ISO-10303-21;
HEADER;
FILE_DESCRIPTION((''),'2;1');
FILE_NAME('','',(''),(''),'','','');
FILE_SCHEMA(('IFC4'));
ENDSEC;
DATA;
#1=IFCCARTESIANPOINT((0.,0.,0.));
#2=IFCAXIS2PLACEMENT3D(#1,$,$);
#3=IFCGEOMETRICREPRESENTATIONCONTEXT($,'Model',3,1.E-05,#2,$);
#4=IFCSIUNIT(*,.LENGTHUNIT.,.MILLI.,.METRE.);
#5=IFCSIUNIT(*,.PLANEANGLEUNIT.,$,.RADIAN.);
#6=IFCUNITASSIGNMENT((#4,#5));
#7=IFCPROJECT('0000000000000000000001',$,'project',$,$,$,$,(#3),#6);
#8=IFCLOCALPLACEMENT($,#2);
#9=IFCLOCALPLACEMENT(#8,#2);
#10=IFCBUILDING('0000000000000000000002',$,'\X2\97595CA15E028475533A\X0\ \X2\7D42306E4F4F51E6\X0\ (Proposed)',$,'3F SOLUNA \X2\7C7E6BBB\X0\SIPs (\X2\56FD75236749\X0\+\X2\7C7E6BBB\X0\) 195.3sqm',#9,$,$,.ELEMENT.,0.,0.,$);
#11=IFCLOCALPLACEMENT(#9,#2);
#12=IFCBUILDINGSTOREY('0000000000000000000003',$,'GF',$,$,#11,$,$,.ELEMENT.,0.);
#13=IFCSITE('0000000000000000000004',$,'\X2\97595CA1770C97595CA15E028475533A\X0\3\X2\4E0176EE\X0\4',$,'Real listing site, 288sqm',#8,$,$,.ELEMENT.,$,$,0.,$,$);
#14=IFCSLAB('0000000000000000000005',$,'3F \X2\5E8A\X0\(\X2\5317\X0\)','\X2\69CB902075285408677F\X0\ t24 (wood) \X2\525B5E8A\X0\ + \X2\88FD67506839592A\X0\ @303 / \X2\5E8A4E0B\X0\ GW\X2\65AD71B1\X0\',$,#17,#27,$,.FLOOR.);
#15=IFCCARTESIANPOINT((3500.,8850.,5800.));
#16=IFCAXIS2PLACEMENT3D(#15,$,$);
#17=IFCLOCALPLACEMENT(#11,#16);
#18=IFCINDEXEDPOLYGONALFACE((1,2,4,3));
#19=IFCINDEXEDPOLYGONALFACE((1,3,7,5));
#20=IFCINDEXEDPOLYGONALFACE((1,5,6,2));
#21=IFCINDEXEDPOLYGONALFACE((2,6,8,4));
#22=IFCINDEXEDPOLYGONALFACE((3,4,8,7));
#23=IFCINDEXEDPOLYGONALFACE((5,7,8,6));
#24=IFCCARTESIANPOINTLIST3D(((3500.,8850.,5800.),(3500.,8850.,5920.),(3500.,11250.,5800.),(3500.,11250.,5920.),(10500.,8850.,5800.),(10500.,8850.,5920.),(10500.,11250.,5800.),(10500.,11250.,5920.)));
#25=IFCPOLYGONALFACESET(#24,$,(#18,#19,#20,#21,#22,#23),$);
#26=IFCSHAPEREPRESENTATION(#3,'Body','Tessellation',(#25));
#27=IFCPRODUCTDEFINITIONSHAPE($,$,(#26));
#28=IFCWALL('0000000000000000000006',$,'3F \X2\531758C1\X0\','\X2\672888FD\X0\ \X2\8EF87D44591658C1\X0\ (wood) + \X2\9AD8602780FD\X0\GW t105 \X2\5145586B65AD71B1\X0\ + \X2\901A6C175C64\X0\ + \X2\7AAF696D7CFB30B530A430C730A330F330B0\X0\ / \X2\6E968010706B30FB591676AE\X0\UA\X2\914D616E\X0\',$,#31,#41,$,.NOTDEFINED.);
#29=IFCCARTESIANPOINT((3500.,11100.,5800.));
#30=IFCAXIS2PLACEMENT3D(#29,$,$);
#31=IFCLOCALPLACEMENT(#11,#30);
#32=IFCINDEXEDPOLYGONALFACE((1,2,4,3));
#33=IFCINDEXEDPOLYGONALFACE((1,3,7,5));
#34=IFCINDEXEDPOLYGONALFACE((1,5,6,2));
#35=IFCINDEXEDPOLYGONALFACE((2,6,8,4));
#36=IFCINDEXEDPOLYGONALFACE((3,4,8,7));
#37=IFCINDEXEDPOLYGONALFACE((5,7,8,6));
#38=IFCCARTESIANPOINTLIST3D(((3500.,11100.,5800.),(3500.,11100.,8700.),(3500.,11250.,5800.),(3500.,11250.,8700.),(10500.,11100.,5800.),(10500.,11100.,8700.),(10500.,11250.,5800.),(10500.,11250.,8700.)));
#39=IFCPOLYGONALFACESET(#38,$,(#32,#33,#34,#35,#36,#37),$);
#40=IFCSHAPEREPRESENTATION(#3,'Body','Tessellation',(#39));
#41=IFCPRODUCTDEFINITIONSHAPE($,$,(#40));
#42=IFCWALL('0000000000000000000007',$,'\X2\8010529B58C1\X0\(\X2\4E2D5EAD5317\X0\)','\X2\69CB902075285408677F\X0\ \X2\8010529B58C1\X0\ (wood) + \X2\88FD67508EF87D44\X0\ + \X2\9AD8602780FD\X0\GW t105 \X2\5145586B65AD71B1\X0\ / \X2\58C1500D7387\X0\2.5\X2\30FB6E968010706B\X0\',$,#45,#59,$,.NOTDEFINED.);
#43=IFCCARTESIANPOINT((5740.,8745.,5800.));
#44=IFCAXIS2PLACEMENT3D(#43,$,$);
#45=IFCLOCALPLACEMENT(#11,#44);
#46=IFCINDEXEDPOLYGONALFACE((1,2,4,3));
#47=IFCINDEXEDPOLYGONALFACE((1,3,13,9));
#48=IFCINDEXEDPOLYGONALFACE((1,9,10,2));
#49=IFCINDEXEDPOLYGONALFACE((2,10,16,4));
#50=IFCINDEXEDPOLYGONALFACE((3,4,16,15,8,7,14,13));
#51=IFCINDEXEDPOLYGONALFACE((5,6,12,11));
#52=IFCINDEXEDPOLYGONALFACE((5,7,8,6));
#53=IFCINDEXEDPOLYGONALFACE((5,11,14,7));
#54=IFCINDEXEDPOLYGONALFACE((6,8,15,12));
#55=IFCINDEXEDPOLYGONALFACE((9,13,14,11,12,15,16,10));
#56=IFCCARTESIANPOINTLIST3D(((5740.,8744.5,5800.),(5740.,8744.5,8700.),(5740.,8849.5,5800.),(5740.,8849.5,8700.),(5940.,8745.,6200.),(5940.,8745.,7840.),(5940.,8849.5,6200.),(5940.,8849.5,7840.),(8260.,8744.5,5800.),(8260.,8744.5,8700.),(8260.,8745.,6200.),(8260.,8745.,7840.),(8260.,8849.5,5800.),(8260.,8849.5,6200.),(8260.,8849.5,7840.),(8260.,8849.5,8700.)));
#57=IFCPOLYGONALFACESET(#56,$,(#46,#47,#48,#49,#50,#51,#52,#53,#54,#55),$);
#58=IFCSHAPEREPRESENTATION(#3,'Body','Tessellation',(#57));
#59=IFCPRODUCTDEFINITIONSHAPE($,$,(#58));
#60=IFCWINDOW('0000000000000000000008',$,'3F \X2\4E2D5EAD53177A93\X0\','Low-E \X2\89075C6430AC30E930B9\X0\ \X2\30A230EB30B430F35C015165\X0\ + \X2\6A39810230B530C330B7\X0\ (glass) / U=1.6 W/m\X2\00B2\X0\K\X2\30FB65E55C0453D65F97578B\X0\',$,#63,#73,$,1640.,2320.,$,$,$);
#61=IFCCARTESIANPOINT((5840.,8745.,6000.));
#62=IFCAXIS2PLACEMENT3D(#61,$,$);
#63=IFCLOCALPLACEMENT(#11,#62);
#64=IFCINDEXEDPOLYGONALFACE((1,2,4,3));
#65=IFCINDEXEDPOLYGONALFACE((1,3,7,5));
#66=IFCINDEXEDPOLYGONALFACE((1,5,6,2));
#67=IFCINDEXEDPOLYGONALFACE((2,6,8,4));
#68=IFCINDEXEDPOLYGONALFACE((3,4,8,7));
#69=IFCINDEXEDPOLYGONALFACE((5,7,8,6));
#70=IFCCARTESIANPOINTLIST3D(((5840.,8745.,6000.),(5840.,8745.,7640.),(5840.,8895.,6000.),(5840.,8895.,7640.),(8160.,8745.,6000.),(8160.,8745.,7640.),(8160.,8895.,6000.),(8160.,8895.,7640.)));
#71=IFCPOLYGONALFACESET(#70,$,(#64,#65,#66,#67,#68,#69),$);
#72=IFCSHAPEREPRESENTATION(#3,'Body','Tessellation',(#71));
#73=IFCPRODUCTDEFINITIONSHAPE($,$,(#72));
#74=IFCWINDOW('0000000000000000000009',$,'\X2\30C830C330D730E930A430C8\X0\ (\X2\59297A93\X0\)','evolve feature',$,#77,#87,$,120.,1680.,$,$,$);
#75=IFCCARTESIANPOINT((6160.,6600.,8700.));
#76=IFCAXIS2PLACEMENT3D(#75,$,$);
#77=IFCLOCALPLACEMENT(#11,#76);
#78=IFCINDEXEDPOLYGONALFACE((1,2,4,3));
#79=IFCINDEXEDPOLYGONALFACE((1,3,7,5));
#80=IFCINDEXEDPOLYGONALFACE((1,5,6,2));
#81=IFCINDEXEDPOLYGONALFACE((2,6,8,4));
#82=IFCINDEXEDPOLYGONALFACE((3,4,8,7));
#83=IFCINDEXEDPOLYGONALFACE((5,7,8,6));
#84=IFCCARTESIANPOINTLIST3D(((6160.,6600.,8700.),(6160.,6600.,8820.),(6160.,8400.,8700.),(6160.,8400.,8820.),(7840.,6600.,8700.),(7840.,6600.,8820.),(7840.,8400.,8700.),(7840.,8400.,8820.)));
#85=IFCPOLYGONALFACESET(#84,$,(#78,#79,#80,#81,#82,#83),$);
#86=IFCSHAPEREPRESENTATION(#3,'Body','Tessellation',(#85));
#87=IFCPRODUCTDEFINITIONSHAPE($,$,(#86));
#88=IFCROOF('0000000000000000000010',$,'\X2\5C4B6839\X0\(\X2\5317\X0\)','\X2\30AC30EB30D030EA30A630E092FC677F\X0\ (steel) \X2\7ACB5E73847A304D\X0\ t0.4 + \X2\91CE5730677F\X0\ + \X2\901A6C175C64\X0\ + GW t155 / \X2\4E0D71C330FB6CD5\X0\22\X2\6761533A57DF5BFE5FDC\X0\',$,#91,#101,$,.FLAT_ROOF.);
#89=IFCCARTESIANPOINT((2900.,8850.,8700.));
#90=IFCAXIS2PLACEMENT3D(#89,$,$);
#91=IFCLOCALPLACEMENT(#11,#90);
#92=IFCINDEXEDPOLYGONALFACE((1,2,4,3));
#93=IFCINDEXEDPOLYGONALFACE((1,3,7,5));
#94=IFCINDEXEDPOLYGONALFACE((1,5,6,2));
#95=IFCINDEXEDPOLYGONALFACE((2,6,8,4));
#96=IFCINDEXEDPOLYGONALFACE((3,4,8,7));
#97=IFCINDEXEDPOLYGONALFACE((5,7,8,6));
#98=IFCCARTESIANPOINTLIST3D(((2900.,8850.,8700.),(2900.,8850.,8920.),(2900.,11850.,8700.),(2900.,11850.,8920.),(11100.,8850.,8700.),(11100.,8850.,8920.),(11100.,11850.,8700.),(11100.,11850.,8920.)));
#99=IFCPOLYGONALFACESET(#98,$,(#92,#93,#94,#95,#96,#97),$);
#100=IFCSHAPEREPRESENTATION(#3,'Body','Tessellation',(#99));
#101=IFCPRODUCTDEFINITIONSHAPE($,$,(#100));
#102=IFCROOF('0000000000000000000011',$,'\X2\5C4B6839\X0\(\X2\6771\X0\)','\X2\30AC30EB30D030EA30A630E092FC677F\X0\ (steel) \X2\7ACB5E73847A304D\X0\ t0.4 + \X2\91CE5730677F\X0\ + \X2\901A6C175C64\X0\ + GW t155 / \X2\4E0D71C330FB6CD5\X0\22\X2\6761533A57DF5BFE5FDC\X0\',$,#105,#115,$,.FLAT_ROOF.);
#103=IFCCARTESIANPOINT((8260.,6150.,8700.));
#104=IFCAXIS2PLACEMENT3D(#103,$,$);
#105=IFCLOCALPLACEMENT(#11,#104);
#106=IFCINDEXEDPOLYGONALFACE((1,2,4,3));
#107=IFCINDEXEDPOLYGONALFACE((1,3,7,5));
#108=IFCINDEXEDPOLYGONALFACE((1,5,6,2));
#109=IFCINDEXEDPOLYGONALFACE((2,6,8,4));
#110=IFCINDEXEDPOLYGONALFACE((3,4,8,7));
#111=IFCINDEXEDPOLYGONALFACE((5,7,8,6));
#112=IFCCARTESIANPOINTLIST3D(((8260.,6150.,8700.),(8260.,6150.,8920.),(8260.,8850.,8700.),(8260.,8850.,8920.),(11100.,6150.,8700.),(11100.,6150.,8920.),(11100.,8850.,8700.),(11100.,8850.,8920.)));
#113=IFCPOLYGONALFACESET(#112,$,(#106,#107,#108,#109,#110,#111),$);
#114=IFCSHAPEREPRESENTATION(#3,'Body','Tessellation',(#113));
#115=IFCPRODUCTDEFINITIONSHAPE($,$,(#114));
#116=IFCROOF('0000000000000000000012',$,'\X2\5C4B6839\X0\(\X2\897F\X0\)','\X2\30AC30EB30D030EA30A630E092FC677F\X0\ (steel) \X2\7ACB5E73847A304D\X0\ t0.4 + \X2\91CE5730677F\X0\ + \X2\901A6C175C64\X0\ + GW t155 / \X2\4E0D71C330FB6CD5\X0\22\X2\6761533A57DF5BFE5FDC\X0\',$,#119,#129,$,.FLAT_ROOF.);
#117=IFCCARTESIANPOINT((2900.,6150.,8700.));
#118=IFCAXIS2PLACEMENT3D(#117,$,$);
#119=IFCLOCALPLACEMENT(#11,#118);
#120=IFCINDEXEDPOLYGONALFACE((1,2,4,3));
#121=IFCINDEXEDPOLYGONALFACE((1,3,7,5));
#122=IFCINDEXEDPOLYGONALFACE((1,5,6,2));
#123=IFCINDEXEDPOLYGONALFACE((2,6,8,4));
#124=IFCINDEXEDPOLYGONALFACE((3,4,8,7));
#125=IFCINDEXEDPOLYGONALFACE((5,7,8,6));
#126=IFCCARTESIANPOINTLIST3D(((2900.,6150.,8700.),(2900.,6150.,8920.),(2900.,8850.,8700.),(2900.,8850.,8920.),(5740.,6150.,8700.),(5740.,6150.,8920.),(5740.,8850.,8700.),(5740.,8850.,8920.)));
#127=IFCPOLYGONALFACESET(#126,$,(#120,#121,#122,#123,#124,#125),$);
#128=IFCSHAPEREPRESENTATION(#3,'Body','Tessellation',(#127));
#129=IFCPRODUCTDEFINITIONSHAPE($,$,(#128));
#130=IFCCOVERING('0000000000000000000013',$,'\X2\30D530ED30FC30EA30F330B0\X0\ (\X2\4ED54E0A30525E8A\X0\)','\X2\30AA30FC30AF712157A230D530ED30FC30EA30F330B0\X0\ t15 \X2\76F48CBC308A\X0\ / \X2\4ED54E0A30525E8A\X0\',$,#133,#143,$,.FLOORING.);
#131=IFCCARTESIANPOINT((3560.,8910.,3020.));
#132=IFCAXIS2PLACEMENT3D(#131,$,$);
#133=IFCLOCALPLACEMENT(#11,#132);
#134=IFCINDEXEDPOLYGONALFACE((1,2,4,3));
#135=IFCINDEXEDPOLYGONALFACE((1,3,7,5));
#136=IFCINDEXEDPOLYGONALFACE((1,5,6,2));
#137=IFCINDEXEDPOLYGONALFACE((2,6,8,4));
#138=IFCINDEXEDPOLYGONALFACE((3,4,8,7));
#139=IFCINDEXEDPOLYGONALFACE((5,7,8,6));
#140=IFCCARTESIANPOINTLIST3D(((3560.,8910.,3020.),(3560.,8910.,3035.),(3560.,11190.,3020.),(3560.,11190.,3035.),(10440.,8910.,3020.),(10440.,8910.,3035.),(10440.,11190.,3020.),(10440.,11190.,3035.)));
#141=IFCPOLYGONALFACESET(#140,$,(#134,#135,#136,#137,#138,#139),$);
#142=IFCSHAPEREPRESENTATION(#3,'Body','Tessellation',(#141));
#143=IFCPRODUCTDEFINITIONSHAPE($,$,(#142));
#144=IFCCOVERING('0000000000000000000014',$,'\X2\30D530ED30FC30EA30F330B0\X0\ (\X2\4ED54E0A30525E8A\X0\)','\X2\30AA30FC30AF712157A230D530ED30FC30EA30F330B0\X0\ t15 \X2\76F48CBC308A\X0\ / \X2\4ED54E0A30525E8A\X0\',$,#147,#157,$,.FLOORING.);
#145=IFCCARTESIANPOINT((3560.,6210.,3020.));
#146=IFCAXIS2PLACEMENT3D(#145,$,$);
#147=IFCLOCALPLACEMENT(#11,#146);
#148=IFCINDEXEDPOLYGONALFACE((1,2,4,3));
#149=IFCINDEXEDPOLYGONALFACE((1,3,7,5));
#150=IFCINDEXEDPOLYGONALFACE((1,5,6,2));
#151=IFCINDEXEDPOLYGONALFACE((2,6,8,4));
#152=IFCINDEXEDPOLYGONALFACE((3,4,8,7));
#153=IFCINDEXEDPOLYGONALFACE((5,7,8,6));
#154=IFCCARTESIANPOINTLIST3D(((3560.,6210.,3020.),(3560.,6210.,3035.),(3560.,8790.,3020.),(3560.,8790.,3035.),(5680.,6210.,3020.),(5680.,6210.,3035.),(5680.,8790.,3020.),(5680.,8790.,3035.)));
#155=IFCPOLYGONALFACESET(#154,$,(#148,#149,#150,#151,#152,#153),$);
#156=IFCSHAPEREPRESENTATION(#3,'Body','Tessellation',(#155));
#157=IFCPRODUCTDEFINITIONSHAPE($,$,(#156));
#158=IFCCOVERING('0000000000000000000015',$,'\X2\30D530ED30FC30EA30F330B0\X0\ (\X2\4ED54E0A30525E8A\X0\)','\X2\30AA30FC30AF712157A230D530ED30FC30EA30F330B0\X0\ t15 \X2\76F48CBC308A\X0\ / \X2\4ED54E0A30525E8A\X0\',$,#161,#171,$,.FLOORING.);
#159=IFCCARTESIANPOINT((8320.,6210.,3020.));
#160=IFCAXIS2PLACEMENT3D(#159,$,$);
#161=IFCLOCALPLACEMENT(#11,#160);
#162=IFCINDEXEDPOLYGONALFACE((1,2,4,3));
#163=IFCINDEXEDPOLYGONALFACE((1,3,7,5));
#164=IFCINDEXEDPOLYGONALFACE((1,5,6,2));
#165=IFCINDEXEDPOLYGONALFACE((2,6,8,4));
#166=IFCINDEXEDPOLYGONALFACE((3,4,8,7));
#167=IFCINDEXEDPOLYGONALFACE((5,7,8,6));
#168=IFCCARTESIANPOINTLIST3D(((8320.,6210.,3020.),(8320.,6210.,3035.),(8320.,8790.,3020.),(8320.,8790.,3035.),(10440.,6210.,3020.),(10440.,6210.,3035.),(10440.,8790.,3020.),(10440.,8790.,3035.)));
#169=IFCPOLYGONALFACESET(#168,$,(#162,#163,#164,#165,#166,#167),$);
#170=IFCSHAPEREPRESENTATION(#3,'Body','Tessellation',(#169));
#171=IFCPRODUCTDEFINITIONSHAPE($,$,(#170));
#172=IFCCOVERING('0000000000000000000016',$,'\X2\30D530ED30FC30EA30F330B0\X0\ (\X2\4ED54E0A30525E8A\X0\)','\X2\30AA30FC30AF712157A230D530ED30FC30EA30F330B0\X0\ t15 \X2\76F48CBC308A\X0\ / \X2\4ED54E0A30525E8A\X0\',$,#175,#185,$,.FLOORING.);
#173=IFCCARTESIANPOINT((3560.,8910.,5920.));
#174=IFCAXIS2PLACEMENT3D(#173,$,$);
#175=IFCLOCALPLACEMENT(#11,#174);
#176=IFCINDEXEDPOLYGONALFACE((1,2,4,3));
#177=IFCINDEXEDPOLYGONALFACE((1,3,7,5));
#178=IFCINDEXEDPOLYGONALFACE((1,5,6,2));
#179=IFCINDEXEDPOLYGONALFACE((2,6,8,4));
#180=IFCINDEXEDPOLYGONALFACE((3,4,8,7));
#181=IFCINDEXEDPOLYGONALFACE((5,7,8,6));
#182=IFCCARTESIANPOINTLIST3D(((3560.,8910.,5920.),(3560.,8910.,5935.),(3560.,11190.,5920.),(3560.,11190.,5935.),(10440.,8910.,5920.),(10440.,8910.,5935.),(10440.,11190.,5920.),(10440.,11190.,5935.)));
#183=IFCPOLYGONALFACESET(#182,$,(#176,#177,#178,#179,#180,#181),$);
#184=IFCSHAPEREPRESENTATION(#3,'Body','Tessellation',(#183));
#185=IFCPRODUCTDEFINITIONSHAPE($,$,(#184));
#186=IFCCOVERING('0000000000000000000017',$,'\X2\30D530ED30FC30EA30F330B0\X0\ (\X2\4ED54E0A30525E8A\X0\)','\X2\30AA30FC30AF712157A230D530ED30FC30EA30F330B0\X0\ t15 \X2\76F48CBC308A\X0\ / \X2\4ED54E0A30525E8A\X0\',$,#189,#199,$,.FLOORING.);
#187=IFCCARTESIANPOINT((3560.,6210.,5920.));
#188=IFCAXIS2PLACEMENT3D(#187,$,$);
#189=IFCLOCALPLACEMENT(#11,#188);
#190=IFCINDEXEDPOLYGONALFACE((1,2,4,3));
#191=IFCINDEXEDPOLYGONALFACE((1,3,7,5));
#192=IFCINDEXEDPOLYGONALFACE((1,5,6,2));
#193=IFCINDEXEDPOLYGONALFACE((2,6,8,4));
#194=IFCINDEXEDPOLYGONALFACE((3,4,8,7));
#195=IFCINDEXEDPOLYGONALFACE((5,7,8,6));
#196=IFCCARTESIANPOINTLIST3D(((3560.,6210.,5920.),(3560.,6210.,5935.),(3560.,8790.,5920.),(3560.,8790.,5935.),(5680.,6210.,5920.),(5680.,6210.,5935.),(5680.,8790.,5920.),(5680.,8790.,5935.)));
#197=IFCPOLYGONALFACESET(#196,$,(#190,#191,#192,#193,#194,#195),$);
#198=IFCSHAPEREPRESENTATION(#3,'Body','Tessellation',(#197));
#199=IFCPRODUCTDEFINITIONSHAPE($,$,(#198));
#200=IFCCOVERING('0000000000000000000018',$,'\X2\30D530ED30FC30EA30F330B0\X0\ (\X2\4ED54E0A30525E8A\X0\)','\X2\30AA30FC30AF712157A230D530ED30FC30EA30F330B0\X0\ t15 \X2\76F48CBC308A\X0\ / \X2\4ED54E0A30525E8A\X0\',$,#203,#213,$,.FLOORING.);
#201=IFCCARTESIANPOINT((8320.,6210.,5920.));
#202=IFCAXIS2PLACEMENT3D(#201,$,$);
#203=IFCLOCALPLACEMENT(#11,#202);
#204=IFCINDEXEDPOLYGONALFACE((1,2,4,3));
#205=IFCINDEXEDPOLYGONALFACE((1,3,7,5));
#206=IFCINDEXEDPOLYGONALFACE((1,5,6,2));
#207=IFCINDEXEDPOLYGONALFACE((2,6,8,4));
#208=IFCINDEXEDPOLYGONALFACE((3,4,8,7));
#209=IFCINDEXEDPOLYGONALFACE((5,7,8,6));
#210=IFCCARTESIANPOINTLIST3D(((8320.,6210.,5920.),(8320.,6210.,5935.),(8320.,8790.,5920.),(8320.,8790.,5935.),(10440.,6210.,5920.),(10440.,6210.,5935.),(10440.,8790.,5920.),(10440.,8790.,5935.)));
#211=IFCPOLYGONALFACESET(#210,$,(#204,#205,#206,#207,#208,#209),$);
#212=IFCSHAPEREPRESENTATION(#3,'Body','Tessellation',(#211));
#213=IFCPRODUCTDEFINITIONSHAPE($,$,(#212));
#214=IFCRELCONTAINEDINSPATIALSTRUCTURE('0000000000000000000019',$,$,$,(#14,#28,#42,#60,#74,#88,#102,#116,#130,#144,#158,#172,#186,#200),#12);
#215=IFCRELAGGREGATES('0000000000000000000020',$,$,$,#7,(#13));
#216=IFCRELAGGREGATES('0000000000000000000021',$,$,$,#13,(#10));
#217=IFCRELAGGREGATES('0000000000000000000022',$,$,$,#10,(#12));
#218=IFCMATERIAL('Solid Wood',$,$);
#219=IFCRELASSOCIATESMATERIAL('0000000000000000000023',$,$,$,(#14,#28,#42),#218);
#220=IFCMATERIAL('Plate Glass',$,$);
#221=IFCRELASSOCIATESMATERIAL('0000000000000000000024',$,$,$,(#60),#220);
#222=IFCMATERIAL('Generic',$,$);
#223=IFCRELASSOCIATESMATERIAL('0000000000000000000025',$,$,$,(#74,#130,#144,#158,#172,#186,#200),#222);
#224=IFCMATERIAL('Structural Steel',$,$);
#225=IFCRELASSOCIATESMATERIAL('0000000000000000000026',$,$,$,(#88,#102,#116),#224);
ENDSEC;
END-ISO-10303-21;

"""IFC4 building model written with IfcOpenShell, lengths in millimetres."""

from ifc_helpers import new_model, si_unit, frame, frame_2d, origin, place, context, project, spatial, rectangle, extrude, material, element, fill, save


model = new_model("IFC4")

# Units and contexts
model_context = context("Model", 3, precision=1e-05, world=origin())
ifc_project = project(units=[si_unit("LENGTHUNIT", "METRE", prefix="MILLI"), si_unit("PLANEANGLEUNIT", "RADIAN")], contexts=[model_context])

# Site, building, storey
site_placement = place(None, origin())
site = spatial("IfcSite", under=ifc_project, at=site_placement, Name="静岡県静岡市葵区3丁目4", ObjectType="Real listing site, 288sqm", CompositionType="ELEMENT", RefElevation=0.0)
building_placement = place(site_placement, origin())
building = spatial("IfcBuilding", under=site, at=building_placement, Name="静岡市葵区 終の住処 (Proposed)", ObjectType="3F SOLUNA 籾殻SIPs (国産杉+籾殻) 195.3sqm", CompositionType="ELEMENT", ElevationOfRefHeight=0.0, ElevationOfTerrain=0.0)
storey_placement = place(building_placement, origin())
storey = spatial("IfcBuildingStorey", under=building, at=storey_placement, Name="GF", CompositionType="ELEMENT", Elevation=0.0)

# Slab
ifc_material_1 = material(Name="Solid Wood")
slab_placement = place(storey_placement, frame((3500.0, 8850.0, 5800.0)))
element("IfcSlab", 1, at=slab_placement, inside=storey, material=ifc_material_1, Name="3F 床(北)", Description="構造用合板 t24 (wood) 剛床 + 製材根太 @303 / 床下 GW断熱", PredefinedType="FLOOR", context=model_context, shape_type="SweptSolid", body=[
    extrude(rectangle(XDim=7000.0, YDim=2400.0, at=frame_2d((3500.0, 1200.0))), frame((3500.0, 8850.0, 5800.0)), (0.0, 0.0, 1.0), 120.0),
])

# Wall
wall_1_placement = place(storey_placement, frame((3500.0, 11100.0, 5800.0)))
element("IfcWall", 2, at=wall_1_placement, inside=storey, material=ifc_material_1, Name="3F 北壁", Description="木製 軸組外壁 (wood) + 高性能GW t105 充填断熱 + 通気層 + 窯業系サイディング / 準耐火・外皮UA配慮", PredefinedType="NOTDEFINED", context=model_context, shape_type="SweptSolid", body=[
    extrude(rectangle(XDim=7000.0, YDim=150.0, at=frame_2d((3500.0, 75.0))), frame((3500.0, 11100.0, 5800.0)), (0.0, 0.0, 1.0), 2900.0),
])

# Wall, opening, window
wall_2_placement = place(storey_placement, frame((5740.0, 8745.0, 5800.0)))
wall_2 = element("IfcWall", 3, at=wall_2_placement, inside=storey, material=ifc_material_1, Name="耐力壁(中庭北)", Description="構造用合板 耐力壁 (wood) + 製材軸組 + 高性能GW t105 充填断熱 / 壁倍率2.5・準耐火", PredefinedType="NOTDEFINED", context=model_context, shape_type="SweptSolid", body=[
    extrude(rectangle(XDim=2520.0, YDim=105.0, at=frame_2d((1260.0, 52.0))), frame((5740.0, 8745.0, 5800.0)), (0.0, 0.0, 1.0), 2900.0),
])
opening_placement = place(storey_placement, frame((5840.0, 8745.0, 6000.0)))
opening = element("IfcOpeningElement", 4, at=opening_placement, cuts=wall_2, PredefinedType="NOTDEFINED", context=model_context, shape_type="SweptSolid", body=[
    extrude(rectangle(XDim=2320.0, YDim=150.0, at=frame_2d((1160.0, 75.0))), frame((5840.0, 8745.0, 6000.0)), (0.0, 0.0, 1.0), 1640.0),
])
ifc_material_2 = material(Name="Plate Glass")
window_1_placement = place(storey_placement, frame((5840.0, 8745.0, 6000.0)))
window_1 = element("IfcWindow", 5, at=window_1_placement, inside=storey, material=ifc_material_2, Name="3F 中庭北窓", Description="Low-E 複層ガラス アルゴン封入 + 樹脂サッシ (glass) / U=1.6 W/m²K・日射取得型", OverallHeight=1640.0, OverallWidth=2320.0, context=model_context, shape_type="SweptSolid", body=[
    extrude(rectangle(XDim=2320.0, YDim=150.0, at=frame_2d((1160.0, 75.0))), frame((5840.0, 8745.0, 6000.0)), (0.0, 0.0, 1.0), 1640.0),
])
fill(opening, window_1)

# Window
ifc_material_3 = material(Name="Generic")
window_2_placement = place(storey_placement, frame((6160.0, 6600.0, 8700.0)))
element("IfcWindow", 6, at=window_2_placement, inside=storey, material=ifc_material_3, Name="トップライト (天窓)", Description="evolve feature", OverallHeight=120.0, OverallWidth=1680.0, context=model_context, shape_type="SweptSolid", body=[
    extrude(rectangle(XDim=1680.0, YDim=1800.0, at=frame_2d((840.0, 900.0))), frame((6160.0, 6600.0, 8700.0)), (0.0, 0.0, 1.0), 120.0),
])

# Roofs
ifc_material_4 = material(Name="Structural Steel")
roof_1_placement = place(storey_placement, frame((2900.0, 8850.0, 8700.0)))
element("IfcRoof", 7, at=roof_1_placement, inside=storey, material=ifc_material_4, Name="屋根(北)", Description="ガルバリウム鋼板 (steel) 立平葺き t0.4 + 野地板 + 通気層 + GW t155 / 不燃・法22条区域対応", PredefinedType="FLAT_ROOF", context=model_context, shape_type="SweptSolid", body=[
    extrude(rectangle(XDim=8200.0, YDim=3000.0, at=frame_2d((4100.0, 1500.0))), frame((2900.0, 8850.0, 8700.0)), (0.0, 0.0, 1.0), 220.0),
])
roof_2_placement = place(storey_placement, frame((8260.0, 6150.0, 8700.0)))
element("IfcRoof", 8, at=roof_2_placement, inside=storey, material=ifc_material_4, Name="屋根(東)", Description="ガルバリウム鋼板 (steel) 立平葺き t0.4 + 野地板 + 通気層 + GW t155 / 不燃・法22条区域対応", PredefinedType="FLAT_ROOF", context=model_context, shape_type="SweptSolid", body=[
    extrude(rectangle(XDim=2840.0, YDim=2700.0, at=frame_2d((1420.0, 1350.0))), frame((8260.0, 6150.0, 8700.0)), (0.0, 0.0, 1.0), 220.0),
])
roof_3_placement = place(storey_placement, frame((2900.0, 6150.0, 8700.0)))
element("IfcRoof", 9, at=roof_3_placement, inside=storey, material=ifc_material_4, Name="屋根(西)", Description="ガルバリウム鋼板 (steel) 立平葺き t0.4 + 野地板 + 通気層 + GW t155 / 不燃・法22条区域対応", PredefinedType="FLAT_ROOF", context=model_context, shape_type="SweptSolid", body=[
    extrude(rectangle(XDim=2840.0, YDim=2700.0, at=frame_2d((1420.0, 1350.0))), frame((2900.0, 6150.0, 8700.0)), (0.0, 0.0, 1.0), 220.0),
])

# Coverings
covering_1_placement = place(storey_placement, frame((3560.0, 8910.0, 3020.0)))
element("IfcCovering", 10, at=covering_1_placement, inside=storey, material=ifc_material_3, Name="フローリング (仕上げ床)", Description="オーク無垢フローリング t15 直貼り / 仕上げ床", PredefinedType="FLOORING", context=model_context, shape_type="SweptSolid", body=[
    extrude(rectangle(XDim=6880.0, YDim=2280.0, at=frame_2d((3440.0, 1140.0))), frame((3560.0, 8910.0, 3020.0)), (0.0, 0.0, 1.0), 15.0),
])
covering_2_placement = place(storey_placement, frame((3560.0, 6210.0, 3020.0)))
element("IfcCovering", 11, at=covering_2_placement, inside=storey, material=ifc_material_3, Name="フローリング (仕上げ床)", Description="オーク無垢フローリング t15 直貼り / 仕上げ床", PredefinedType="FLOORING", context=model_context, shape_type="SweptSolid", body=[
    extrude(rectangle(XDim=2120.0, YDim=2580.0, at=frame_2d((1060.0, 1290.0))), frame((3560.0, 6210.0, 3020.0)), (0.0, 0.0, 1.0), 15.0),
])
covering_3_placement = place(storey_placement, frame((8320.0, 6210.0, 3020.0)))
element("IfcCovering", 12, at=covering_3_placement, inside=storey, material=ifc_material_3, Name="フローリング (仕上げ床)", Description="オーク無垢フローリング t15 直貼り / 仕上げ床", PredefinedType="FLOORING", context=model_context, shape_type="SweptSolid", body=[
    extrude(rectangle(XDim=2120.0, YDim=2580.0, at=frame_2d((1060.0, 1290.0))), frame((8320.0, 6210.0, 3020.0)), (0.0, 0.0, 1.0), 15.0),
])
covering_4_placement = place(storey_placement, frame((3560.0, 8910.0, 5920.0)))
element("IfcCovering", 13, at=covering_4_placement, inside=storey, material=ifc_material_3, Name="フローリング (仕上げ床)", Description="オーク無垢フローリング t15 直貼り / 仕上げ床", PredefinedType="FLOORING", context=model_context, shape_type="SweptSolid", body=[
    extrude(rectangle(XDim=6880.0, YDim=2280.0, at=frame_2d((3440.0, 1140.0))), frame((3560.0, 8910.0, 5920.0)), (0.0, 0.0, 1.0), 15.0),
])
covering_5_placement = place(storey_placement, frame((3560.0, 6210.0, 5920.0)))
element("IfcCovering", 14, at=covering_5_placement, inside=storey, material=ifc_material_3, Name="フローリング (仕上げ床)", Description="オーク無垢フローリング t15 直貼り / 仕上げ床", PredefinedType="FLOORING", context=model_context, shape_type="SweptSolid", body=[
    extrude(rectangle(XDim=2120.0, YDim=2580.0, at=frame_2d((1060.0, 1290.0))), frame((3560.0, 6210.0, 5920.0)), (0.0, 0.0, 1.0), 15.0),
])
covering_6_placement = place(storey_placement, frame((8320.0, 6210.0, 5920.0)))
element("IfcCovering", 15, at=covering_6_placement, inside=storey, material=ifc_material_3, Name="フローリング (仕上げ床)", Description="オーク無垢フローリング t15 直貼り / 仕上げ床", PredefinedType="FLOORING", context=model_context, shape_type="SweptSolid", body=[
    extrude(rectangle(XDim=2120.0, YDim=2580.0, at=frame_2d((1060.0, 1290.0))), frame((8320.0, 6210.0, 5920.0)), (0.0, 0.0, 1.0), 15.0),
])

save(model, "model.ifc")
